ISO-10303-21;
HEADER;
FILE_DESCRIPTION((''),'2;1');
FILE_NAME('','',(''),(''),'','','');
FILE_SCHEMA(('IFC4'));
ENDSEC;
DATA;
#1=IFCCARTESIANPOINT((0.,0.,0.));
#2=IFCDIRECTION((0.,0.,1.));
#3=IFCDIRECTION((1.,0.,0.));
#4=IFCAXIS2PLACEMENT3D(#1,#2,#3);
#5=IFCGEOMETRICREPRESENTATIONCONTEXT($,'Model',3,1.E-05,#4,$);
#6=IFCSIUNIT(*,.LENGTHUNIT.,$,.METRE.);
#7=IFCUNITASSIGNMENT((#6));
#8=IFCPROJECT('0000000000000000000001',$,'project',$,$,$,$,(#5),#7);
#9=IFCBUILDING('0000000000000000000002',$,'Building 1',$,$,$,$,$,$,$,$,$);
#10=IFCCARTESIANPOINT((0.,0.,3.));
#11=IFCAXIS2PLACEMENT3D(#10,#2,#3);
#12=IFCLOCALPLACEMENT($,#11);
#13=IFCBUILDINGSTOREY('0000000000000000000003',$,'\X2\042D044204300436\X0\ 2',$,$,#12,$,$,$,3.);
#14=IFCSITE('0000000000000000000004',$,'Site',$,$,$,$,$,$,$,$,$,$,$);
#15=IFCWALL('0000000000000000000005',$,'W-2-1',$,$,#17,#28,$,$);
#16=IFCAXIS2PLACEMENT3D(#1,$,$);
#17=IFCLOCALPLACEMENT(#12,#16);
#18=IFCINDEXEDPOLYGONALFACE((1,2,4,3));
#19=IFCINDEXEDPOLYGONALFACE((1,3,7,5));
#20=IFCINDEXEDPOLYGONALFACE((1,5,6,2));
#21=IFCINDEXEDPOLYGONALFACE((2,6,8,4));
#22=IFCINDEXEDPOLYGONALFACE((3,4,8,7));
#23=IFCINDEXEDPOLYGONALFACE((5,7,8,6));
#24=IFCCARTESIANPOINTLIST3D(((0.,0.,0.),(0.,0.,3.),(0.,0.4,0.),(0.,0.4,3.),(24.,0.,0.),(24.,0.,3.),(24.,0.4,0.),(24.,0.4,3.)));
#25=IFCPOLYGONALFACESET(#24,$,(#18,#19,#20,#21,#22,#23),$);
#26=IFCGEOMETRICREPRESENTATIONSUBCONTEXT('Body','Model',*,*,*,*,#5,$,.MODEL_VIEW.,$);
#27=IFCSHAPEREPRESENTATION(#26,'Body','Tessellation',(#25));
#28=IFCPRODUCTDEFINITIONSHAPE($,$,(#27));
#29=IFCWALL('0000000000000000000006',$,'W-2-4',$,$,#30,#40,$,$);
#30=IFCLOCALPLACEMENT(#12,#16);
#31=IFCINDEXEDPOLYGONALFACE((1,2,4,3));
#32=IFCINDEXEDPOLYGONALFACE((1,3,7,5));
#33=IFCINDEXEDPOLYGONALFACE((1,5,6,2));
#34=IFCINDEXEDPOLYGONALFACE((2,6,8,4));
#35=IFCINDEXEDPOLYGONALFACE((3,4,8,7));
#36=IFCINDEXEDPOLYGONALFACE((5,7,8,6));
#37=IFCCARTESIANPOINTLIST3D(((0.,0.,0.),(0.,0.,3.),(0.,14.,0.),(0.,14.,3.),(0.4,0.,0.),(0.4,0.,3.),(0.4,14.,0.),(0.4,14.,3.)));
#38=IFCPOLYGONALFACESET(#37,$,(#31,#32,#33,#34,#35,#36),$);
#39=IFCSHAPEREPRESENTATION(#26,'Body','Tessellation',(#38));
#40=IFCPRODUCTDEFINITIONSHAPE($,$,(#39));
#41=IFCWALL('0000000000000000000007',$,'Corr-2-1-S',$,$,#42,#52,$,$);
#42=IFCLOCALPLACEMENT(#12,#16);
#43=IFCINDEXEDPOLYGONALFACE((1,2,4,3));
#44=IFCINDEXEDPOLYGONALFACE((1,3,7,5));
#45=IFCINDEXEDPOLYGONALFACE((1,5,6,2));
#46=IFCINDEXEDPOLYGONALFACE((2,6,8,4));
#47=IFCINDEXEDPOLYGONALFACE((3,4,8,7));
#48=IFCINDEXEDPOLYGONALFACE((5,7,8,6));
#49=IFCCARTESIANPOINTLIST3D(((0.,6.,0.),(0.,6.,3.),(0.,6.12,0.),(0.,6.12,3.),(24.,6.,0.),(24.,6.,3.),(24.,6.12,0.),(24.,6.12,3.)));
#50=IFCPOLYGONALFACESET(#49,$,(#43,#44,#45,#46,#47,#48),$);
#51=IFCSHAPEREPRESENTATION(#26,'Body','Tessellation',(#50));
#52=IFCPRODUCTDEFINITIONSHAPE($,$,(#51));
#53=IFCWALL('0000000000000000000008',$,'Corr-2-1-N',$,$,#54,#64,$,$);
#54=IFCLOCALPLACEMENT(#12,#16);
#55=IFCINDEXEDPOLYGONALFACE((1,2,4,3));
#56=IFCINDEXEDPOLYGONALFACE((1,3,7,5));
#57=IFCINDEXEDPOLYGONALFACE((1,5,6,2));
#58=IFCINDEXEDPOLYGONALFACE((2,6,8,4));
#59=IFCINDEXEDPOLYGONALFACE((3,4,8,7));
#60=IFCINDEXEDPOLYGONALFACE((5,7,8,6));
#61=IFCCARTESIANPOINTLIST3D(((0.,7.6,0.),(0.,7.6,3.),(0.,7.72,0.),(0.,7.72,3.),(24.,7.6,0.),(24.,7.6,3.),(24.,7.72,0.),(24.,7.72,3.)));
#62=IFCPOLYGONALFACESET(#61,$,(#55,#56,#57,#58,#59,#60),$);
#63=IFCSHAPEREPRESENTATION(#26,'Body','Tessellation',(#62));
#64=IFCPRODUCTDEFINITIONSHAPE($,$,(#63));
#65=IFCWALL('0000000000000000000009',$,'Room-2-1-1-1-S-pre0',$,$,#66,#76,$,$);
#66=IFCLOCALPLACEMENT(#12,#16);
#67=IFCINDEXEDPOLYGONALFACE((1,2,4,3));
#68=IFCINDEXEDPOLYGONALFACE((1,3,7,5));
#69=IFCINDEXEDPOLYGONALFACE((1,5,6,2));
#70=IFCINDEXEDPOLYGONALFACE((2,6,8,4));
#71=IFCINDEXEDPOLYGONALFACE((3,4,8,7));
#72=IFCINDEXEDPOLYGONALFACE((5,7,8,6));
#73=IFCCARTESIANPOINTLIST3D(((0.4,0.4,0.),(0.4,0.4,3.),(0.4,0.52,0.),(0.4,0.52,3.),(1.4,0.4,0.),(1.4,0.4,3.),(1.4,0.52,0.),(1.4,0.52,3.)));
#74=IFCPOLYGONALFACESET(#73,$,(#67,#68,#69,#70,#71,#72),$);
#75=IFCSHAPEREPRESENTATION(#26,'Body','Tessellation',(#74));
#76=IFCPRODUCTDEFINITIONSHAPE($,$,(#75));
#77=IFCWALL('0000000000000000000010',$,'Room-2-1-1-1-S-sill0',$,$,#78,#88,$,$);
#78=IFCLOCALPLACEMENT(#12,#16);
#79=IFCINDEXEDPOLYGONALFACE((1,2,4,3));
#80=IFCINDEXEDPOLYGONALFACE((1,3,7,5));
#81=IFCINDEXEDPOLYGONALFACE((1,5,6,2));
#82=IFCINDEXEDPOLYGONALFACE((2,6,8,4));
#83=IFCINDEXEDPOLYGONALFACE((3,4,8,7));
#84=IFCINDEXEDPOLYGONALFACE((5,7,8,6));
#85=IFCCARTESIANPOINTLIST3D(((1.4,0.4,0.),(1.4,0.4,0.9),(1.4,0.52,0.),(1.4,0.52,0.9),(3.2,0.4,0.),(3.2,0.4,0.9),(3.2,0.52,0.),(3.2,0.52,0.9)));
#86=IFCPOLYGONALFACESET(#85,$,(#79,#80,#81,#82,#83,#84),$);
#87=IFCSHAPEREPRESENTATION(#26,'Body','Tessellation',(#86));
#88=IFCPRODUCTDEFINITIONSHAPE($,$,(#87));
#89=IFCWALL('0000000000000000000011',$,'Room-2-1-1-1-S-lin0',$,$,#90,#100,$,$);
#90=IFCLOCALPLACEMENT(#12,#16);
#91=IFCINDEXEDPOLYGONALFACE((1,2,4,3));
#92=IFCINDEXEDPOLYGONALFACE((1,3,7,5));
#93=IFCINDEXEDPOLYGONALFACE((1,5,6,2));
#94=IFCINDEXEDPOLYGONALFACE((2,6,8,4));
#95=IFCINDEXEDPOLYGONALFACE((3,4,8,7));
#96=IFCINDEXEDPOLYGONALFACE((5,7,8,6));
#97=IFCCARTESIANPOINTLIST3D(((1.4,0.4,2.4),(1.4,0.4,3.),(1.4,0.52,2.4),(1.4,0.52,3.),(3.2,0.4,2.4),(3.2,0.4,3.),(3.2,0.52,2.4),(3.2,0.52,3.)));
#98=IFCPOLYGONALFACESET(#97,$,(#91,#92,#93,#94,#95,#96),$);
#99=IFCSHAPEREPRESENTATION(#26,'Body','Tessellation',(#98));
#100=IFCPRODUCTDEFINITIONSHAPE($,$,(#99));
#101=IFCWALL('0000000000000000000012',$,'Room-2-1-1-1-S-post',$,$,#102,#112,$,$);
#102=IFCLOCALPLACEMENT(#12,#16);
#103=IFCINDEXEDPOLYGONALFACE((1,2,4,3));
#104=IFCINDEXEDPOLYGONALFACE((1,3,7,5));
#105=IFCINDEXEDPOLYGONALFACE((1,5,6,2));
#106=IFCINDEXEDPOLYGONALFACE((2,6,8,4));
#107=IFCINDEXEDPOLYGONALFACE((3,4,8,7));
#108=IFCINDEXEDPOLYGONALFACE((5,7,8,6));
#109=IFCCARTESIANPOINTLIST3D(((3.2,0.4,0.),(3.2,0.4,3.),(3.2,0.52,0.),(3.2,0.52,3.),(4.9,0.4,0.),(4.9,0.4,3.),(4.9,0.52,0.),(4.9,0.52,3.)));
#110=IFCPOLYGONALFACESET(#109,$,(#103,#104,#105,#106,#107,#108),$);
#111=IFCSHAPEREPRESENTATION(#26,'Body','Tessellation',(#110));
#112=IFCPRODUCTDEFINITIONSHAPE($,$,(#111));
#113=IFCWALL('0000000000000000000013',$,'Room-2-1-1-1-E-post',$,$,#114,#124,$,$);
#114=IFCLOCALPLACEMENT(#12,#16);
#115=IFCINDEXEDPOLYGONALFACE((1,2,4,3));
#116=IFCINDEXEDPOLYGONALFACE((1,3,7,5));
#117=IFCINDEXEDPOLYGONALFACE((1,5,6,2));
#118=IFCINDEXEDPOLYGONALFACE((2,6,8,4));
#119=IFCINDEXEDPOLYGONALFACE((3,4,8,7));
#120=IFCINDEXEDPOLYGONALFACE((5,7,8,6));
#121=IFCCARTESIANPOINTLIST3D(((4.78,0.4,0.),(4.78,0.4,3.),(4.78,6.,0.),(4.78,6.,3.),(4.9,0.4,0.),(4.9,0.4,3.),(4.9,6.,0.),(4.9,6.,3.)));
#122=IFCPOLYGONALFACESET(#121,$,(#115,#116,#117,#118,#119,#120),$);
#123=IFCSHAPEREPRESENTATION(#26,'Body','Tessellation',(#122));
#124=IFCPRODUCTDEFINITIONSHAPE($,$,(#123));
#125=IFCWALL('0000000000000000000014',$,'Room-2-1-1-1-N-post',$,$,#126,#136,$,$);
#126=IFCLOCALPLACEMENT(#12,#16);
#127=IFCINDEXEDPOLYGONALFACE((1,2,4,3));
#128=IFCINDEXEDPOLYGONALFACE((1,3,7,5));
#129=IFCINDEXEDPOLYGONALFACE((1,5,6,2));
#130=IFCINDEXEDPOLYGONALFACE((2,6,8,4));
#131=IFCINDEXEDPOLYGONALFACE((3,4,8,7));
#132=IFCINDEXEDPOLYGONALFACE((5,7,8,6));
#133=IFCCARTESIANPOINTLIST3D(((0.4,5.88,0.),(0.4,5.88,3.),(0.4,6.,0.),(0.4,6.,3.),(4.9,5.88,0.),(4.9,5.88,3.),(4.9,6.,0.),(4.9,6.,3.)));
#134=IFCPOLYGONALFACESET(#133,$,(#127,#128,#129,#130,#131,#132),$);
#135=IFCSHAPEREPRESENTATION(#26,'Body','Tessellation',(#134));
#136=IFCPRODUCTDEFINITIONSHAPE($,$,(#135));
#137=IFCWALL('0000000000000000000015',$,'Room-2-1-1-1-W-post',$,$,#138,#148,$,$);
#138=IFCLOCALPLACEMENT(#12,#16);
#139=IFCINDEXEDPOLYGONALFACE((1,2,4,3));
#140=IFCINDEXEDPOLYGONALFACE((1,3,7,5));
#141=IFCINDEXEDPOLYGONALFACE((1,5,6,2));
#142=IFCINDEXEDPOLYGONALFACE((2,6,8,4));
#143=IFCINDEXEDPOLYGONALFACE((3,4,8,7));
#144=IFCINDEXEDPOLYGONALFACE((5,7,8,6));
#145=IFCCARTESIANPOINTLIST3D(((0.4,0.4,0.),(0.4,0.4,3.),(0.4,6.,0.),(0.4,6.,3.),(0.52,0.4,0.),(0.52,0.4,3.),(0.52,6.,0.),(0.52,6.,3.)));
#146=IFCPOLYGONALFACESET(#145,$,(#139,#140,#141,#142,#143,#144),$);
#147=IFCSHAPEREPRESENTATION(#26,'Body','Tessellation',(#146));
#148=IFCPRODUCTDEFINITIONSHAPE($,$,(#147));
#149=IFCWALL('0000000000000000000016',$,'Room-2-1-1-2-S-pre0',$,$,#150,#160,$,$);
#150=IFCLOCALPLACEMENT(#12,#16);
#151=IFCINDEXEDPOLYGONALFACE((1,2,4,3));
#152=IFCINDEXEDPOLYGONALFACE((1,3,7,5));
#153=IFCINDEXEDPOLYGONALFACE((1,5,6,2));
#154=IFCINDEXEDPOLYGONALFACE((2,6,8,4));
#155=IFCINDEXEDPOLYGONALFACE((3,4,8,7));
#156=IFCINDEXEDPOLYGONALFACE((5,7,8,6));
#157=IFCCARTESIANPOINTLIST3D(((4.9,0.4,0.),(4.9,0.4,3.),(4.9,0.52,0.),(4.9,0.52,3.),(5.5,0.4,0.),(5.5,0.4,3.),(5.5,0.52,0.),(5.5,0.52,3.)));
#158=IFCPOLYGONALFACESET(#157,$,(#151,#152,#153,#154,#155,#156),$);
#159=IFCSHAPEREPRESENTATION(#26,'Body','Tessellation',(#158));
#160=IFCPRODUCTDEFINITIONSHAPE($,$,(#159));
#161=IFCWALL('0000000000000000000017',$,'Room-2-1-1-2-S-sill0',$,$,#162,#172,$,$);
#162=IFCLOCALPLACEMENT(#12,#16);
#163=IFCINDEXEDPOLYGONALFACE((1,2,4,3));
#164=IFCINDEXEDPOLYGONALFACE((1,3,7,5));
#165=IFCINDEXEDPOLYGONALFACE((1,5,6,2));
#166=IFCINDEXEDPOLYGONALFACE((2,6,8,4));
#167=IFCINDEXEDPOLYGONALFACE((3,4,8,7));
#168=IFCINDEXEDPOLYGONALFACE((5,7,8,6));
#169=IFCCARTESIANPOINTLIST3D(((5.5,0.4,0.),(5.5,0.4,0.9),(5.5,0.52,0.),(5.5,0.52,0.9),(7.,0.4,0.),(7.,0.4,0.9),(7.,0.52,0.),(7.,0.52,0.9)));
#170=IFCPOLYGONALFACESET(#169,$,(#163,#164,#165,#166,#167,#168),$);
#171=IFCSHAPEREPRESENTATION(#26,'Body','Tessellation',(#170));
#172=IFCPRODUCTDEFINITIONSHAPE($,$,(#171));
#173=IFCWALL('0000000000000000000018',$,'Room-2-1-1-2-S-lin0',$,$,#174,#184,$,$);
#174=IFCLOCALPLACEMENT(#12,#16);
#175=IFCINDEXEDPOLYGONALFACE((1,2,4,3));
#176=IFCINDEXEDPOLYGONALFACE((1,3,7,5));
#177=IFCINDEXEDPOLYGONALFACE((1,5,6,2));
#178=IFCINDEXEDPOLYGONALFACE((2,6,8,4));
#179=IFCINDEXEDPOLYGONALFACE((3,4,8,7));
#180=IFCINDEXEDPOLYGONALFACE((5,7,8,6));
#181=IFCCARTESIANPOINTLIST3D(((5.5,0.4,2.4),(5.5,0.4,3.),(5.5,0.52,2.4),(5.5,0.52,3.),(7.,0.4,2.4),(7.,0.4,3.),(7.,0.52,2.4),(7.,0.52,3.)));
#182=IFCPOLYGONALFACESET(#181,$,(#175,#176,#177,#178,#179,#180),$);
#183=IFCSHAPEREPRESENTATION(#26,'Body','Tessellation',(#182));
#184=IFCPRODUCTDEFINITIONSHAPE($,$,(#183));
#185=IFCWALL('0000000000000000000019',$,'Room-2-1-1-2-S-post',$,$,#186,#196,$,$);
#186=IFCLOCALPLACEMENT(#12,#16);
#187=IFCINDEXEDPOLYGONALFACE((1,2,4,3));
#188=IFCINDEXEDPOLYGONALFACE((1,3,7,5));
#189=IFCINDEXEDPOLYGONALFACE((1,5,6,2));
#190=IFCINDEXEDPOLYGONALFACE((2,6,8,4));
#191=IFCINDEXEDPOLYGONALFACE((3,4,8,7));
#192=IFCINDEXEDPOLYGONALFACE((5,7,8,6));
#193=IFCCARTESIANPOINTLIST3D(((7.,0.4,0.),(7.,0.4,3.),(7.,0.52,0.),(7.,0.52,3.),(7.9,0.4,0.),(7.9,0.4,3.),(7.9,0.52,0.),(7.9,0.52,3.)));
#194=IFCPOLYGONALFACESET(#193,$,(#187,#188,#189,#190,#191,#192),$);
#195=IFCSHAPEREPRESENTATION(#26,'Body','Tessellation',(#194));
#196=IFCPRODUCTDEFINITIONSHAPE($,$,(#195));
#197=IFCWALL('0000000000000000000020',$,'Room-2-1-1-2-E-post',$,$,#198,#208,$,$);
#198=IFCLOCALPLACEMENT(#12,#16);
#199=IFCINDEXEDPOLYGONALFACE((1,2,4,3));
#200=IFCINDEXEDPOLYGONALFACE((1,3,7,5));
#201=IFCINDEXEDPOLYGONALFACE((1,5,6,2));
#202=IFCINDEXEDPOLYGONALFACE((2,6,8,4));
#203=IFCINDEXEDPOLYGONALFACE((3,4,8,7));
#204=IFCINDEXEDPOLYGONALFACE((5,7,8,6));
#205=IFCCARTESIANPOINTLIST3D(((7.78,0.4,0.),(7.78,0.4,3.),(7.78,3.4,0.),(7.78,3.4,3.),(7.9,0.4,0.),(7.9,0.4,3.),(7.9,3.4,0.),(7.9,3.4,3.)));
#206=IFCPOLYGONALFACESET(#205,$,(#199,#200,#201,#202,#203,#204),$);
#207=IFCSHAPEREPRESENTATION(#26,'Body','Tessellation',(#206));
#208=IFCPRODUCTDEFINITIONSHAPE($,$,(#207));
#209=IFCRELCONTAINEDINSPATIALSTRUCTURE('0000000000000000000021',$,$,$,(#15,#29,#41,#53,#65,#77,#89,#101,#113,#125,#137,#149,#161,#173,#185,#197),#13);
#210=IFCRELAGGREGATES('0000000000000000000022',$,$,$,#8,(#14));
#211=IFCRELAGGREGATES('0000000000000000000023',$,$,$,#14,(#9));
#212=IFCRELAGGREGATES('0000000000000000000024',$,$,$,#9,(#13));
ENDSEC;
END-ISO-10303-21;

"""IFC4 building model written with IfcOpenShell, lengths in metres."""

from ifc_helpers import new_model, si_unit, frame, origin_with_axes, place, context, subcontext, project, spatial, indexed_curve, outline, extrude, element, save


model = new_model("IFC4")

# Units and contexts
model_context = context("Model", 3, precision=1e-05, world=origin_with_axes())
body_context = subcontext(model_context, "Body", "Model", "MODEL_VIEW")
ifc_project = project(units=[si_unit("LENGTHUNIT", "METRE")], contexts=[model_context])

# Site, building, storey
site = spatial("IfcSite", under=ifc_project, Name="Site")
building = spatial("IfcBuilding", under=site, Name="Building 1")
storey_placement = place(None, frame((0.0, 0.0, 3.0), z_axis=(0.0, 0.0, 1.0), x_axis=(1.0, 0.0, 0.0)))
storey = spatial("IfcBuildingStorey", under=building, at=storey_placement, Name="Этаж 2", Elevation=3.0)

# Walls
wall_1_placement = place(storey_placement, origin_with_axes())
element("IfcWall", 1, at=wall_1_placement, inside=storey, Name="W-2-1", context=body_context, shape_type="SweptSolid", body=[
    extrude(outline(indexed_curve([(0.0, 0.0), (0.0, 0.4), (24.0, 0.4), (24.0, 0.0), (0.0, 0.0)], self_intersect=False)), origin_with_axes(), (0.0, 0.0, 1.0), 3.0),
])
wall_2_placement = place(storey_placement, frame((0.0, 14.0, 0.0), z_axis=(0.0, 0.0, 1.0), x_axis=(0.0, -1.0, 0.0)))
element("IfcWall", 2, at=wall_2_placement, inside=storey, Name="W-2-4", context=body_context, shape_type="SweptSolid", body=[
    extrude(outline(indexed_curve([(0.0, 0.0), (0.0, 0.4), (14.0, 0.4), (14.0, 0.0), (0.0, 0.0)], self_intersect=False)), origin_with_axes(), (0.0, 0.0, 1.0), 3.0),
])
for number, where, z_axis, x_axis, name in (
    (3, (0.0, 6.0, 0.0), (0.0, 0.0, 1.0), (1.0, 0.0, 0.0), "Corr-2-1-S"),
    (4, (0.0, 7.6, 0.0), (0.0, 0.0, 1.0), (1.0, 0.0, 0.0), "Corr-2-1-N"),
):
    element("IfcWall", number, at=place(storey_placement, frame(where, z_axis=z_axis, x_axis=x_axis)), inside=storey, Name=name, context=body_context, shape_type="SweptSolid", body=[
        extrude(outline(indexed_curve([(0.0, 0.0), (0.0, 0.12), (24.0, 0.12), (24.0, 0.0), (0.0, 0.0)], self_intersect=False)), origin_with_axes(), (0.0, 0.0, 1.0), 3.0),
    ])
wall_3_placement = place(storey_placement, frame((0.4, 0.4, 0.0), z_axis=(0.0, 0.0, 1.0), x_axis=(1.0, 0.0, 0.0)))
element("IfcWall", 5, at=wall_3_placement, inside=storey, Name="Room-2-1-1-1-S-pre0", context=body_context, shape_type="SweptSolid", body=[
    extrude(outline(indexed_curve([(0.0, 0.0), (0.0, 0.12), (1.0, 0.12), (1.0, 0.0), (0.0, 0.0)], self_intersect=False)), origin_with_axes(), (0.0, 0.0, 1.0), 3.0),
])
wall_4_placement = place(storey_placement, frame((1.4, 0.4, 0.0), z_axis=(0.0, 0.0, 1.0), x_axis=(1.0, 0.0, 0.0)))
element("IfcWall", 6, at=wall_4_placement, inside=storey, Name="Room-2-1-1-1-S-sill0", context=body_context, shape_type="SweptSolid", body=[
    extrude(outline(indexed_curve([(0.0, 0.0), (0.0, 0.12), (1.8, 0.12), (1.8, 0.0), (0.0, 0.0)], self_intersect=False)), origin_with_axes(), (0.0, 0.0, 1.0), 0.9),
])
wall_5_placement = place(storey_placement, frame((1.4, 0.4, 2.4), z_axis=(0.0, 0.0, 1.0), x_axis=(1.0, 0.0, 0.0)))
element("IfcWall", 7, at=wall_5_placement, inside=storey, Name="Room-2-1-1-1-S-lin0", context=body_context, shape_type="SweptSolid", body=[
    extrude(outline(indexed_curve([(0.0, 0.0), (0.0, 0.12), (1.8, 0.12), (1.8, 0.0), (0.0, 0.0)], self_intersect=False)), origin_with_axes(), (0.0, 0.0, 1.0), 0.6),
])
wall_6_placement = place(storey_placement, frame((3.2, 0.4, 0.0), z_axis=(0.0, 0.0, 1.0), x_axis=(1.0, 0.0, 0.0)))
element("IfcWall", 8, at=wall_6_placement, inside=storey, Name="Room-2-1-1-1-S-post", context=body_context, shape_type="SweptSolid", body=[
    extrude(outline(indexed_curve([(0.0, 0.0), (0.0, 0.12), (1.7, 0.12), (1.7, 0.0), (0.0, 0.0)], self_intersect=False)), origin_with_axes(), (0.0, 0.0, 1.0), 3.0),
])
wall_7_placement = place(storey_placement, frame((4.9, 0.4, 0.0), z_axis=(0.0, 0.0, 1.0), x_axis=(0.0, 1.0, 0.0)))
element("IfcWall", 9, at=wall_7_placement, inside=storey, Name="Room-2-1-1-1-E-post", context=body_context, shape_type="SweptSolid", body=[
    extrude(outline(indexed_curve([(0.0, 0.0), (0.0, 0.12), (5.6, 0.12), (5.6, 0.0), (0.0, 0.0)], self_intersect=False)), origin_with_axes(), (0.0, 0.0, 1.0), 3.0),
])
wall_8_placement = place(storey_placement, frame((4.9, 6.0, 0.0), z_axis=(0.0, 0.0, 1.0), x_axis=(-1.0, 0.0, 0.0)))
element("IfcWall", 10, at=wall_8_placement, inside=storey, Name="Room-2-1-1-1-N-post", context=body_context, shape_type="SweptSolid", body=[
    extrude(outline(indexed_curve([(0.0, 0.0), (0.0, 0.12), (4.5, 0.12), (4.5, 0.0), (0.0, 0.0)], self_intersect=False)), origin_with_axes(), (0.0, 0.0, 1.0), 3.0),
])
wall_9_placement = place(storey_placement, frame((0.4, 6.0, 0.0), z_axis=(0.0, 0.0, 1.0), x_axis=(0.0, -1.0, 0.0)))
element("IfcWall", 11, at=wall_9_placement, inside=storey, Name="Room-2-1-1-1-W-post", context=body_context, shape_type="SweptSolid", body=[
    extrude(outline(indexed_curve([(0.0, 0.0), (0.0, 0.12), (5.6, 0.12), (5.6, 0.0), (0.0, 0.0)], self_intersect=False)), origin_with_axes(), (0.0, 0.0, 1.0), 3.0),
])
wall_10_placement = place(storey_placement, frame((4.9, 0.4, 0.0), z_axis=(0.0, 0.0, 1.0), x_axis=(1.0, 0.0, 0.0)))
element("IfcWall", 12, at=wall_10_placement, inside=storey, Name="Room-2-1-1-2-S-pre0", context=body_context, shape_type="SweptSolid", body=[
    extrude(outline(indexed_curve([(0.0, 0.0), (0.0, 0.12), (0.6, 0.12), (0.6, 0.0), (0.0, 0.0)], self_intersect=False)), origin_with_axes(), (0.0, 0.0, 1.0), 3.0),
])
wall_11_placement = place(storey_placement, frame((5.5, 0.4, 0.0), z_axis=(0.0, 0.0, 1.0), x_axis=(1.0, 0.0, 0.0)))
element("IfcWall", 13, at=wall_11_placement, inside=storey, Name="Room-2-1-1-2-S-sill0", context=body_context, shape_type="SweptSolid", body=[
    extrude(outline(indexed_curve([(0.0, 0.0), (0.0, 0.12), (1.5, 0.12), (1.5, 0.0), (0.0, 0.0)], self_intersect=False)), origin_with_axes(), (0.0, 0.0, 1.0), 0.9),
])
wall_12_placement = place(storey_placement, frame((5.5, 0.4, 2.4), z_axis=(0.0, 0.0, 1.0), x_axis=(1.0, 0.0, 0.0)))
element("IfcWall", 14, at=wall_12_placement, inside=storey, Name="Room-2-1-1-2-S-lin0", context=body_context, shape_type="SweptSolid", body=[
    extrude(outline(indexed_curve([(0.0, 0.0), (0.0, 0.12), (1.5, 0.12), (1.5, 0.0), (0.0, 0.0)], self_intersect=False)), origin_with_axes(), (0.0, 0.0, 1.0), 0.6),
])
wall_13_placement = place(storey_placement, frame((7.0, 0.4, 0.0), z_axis=(0.0, 0.0, 1.0), x_axis=(1.0, 0.0, 0.0)))
element("IfcWall", 15, at=wall_13_placement, inside=storey, Name="Room-2-1-1-2-S-post", context=body_context, shape_type="SweptSolid", body=[
    extrude(outline(indexed_curve([(0.0, 0.0), (0.0, 0.12), (0.9, 0.12), (0.9, 0.0), (0.0, 0.0)], self_intersect=False)), origin_with_axes(), (0.0, 0.0, 1.0), 3.0),
])
for number, where, z_axis, x_axis, name in (
    (16, (7.9, 0.4, 0.0), (0.0, 0.0, 1.0), (0.0, 1.0, 0.0), "Room-2-1-1-2-E-post"),
):
    element("IfcWall", number, at=place(storey_placement, frame(where, z_axis=z_axis, x_axis=x_axis)), inside=storey, Name=name, context=body_context, shape_type="SweptSolid", body=[
        extrude(outline(indexed_curve([(0.0, 0.0), (0.0, 0.12), (3.0, 0.12), (3.0, 0.0), (0.0, 0.0)], self_intersect=False)), origin_with_axes(), (0.0, 0.0, 1.0), 3.0),
    ])

save(model, "model.ifc")
